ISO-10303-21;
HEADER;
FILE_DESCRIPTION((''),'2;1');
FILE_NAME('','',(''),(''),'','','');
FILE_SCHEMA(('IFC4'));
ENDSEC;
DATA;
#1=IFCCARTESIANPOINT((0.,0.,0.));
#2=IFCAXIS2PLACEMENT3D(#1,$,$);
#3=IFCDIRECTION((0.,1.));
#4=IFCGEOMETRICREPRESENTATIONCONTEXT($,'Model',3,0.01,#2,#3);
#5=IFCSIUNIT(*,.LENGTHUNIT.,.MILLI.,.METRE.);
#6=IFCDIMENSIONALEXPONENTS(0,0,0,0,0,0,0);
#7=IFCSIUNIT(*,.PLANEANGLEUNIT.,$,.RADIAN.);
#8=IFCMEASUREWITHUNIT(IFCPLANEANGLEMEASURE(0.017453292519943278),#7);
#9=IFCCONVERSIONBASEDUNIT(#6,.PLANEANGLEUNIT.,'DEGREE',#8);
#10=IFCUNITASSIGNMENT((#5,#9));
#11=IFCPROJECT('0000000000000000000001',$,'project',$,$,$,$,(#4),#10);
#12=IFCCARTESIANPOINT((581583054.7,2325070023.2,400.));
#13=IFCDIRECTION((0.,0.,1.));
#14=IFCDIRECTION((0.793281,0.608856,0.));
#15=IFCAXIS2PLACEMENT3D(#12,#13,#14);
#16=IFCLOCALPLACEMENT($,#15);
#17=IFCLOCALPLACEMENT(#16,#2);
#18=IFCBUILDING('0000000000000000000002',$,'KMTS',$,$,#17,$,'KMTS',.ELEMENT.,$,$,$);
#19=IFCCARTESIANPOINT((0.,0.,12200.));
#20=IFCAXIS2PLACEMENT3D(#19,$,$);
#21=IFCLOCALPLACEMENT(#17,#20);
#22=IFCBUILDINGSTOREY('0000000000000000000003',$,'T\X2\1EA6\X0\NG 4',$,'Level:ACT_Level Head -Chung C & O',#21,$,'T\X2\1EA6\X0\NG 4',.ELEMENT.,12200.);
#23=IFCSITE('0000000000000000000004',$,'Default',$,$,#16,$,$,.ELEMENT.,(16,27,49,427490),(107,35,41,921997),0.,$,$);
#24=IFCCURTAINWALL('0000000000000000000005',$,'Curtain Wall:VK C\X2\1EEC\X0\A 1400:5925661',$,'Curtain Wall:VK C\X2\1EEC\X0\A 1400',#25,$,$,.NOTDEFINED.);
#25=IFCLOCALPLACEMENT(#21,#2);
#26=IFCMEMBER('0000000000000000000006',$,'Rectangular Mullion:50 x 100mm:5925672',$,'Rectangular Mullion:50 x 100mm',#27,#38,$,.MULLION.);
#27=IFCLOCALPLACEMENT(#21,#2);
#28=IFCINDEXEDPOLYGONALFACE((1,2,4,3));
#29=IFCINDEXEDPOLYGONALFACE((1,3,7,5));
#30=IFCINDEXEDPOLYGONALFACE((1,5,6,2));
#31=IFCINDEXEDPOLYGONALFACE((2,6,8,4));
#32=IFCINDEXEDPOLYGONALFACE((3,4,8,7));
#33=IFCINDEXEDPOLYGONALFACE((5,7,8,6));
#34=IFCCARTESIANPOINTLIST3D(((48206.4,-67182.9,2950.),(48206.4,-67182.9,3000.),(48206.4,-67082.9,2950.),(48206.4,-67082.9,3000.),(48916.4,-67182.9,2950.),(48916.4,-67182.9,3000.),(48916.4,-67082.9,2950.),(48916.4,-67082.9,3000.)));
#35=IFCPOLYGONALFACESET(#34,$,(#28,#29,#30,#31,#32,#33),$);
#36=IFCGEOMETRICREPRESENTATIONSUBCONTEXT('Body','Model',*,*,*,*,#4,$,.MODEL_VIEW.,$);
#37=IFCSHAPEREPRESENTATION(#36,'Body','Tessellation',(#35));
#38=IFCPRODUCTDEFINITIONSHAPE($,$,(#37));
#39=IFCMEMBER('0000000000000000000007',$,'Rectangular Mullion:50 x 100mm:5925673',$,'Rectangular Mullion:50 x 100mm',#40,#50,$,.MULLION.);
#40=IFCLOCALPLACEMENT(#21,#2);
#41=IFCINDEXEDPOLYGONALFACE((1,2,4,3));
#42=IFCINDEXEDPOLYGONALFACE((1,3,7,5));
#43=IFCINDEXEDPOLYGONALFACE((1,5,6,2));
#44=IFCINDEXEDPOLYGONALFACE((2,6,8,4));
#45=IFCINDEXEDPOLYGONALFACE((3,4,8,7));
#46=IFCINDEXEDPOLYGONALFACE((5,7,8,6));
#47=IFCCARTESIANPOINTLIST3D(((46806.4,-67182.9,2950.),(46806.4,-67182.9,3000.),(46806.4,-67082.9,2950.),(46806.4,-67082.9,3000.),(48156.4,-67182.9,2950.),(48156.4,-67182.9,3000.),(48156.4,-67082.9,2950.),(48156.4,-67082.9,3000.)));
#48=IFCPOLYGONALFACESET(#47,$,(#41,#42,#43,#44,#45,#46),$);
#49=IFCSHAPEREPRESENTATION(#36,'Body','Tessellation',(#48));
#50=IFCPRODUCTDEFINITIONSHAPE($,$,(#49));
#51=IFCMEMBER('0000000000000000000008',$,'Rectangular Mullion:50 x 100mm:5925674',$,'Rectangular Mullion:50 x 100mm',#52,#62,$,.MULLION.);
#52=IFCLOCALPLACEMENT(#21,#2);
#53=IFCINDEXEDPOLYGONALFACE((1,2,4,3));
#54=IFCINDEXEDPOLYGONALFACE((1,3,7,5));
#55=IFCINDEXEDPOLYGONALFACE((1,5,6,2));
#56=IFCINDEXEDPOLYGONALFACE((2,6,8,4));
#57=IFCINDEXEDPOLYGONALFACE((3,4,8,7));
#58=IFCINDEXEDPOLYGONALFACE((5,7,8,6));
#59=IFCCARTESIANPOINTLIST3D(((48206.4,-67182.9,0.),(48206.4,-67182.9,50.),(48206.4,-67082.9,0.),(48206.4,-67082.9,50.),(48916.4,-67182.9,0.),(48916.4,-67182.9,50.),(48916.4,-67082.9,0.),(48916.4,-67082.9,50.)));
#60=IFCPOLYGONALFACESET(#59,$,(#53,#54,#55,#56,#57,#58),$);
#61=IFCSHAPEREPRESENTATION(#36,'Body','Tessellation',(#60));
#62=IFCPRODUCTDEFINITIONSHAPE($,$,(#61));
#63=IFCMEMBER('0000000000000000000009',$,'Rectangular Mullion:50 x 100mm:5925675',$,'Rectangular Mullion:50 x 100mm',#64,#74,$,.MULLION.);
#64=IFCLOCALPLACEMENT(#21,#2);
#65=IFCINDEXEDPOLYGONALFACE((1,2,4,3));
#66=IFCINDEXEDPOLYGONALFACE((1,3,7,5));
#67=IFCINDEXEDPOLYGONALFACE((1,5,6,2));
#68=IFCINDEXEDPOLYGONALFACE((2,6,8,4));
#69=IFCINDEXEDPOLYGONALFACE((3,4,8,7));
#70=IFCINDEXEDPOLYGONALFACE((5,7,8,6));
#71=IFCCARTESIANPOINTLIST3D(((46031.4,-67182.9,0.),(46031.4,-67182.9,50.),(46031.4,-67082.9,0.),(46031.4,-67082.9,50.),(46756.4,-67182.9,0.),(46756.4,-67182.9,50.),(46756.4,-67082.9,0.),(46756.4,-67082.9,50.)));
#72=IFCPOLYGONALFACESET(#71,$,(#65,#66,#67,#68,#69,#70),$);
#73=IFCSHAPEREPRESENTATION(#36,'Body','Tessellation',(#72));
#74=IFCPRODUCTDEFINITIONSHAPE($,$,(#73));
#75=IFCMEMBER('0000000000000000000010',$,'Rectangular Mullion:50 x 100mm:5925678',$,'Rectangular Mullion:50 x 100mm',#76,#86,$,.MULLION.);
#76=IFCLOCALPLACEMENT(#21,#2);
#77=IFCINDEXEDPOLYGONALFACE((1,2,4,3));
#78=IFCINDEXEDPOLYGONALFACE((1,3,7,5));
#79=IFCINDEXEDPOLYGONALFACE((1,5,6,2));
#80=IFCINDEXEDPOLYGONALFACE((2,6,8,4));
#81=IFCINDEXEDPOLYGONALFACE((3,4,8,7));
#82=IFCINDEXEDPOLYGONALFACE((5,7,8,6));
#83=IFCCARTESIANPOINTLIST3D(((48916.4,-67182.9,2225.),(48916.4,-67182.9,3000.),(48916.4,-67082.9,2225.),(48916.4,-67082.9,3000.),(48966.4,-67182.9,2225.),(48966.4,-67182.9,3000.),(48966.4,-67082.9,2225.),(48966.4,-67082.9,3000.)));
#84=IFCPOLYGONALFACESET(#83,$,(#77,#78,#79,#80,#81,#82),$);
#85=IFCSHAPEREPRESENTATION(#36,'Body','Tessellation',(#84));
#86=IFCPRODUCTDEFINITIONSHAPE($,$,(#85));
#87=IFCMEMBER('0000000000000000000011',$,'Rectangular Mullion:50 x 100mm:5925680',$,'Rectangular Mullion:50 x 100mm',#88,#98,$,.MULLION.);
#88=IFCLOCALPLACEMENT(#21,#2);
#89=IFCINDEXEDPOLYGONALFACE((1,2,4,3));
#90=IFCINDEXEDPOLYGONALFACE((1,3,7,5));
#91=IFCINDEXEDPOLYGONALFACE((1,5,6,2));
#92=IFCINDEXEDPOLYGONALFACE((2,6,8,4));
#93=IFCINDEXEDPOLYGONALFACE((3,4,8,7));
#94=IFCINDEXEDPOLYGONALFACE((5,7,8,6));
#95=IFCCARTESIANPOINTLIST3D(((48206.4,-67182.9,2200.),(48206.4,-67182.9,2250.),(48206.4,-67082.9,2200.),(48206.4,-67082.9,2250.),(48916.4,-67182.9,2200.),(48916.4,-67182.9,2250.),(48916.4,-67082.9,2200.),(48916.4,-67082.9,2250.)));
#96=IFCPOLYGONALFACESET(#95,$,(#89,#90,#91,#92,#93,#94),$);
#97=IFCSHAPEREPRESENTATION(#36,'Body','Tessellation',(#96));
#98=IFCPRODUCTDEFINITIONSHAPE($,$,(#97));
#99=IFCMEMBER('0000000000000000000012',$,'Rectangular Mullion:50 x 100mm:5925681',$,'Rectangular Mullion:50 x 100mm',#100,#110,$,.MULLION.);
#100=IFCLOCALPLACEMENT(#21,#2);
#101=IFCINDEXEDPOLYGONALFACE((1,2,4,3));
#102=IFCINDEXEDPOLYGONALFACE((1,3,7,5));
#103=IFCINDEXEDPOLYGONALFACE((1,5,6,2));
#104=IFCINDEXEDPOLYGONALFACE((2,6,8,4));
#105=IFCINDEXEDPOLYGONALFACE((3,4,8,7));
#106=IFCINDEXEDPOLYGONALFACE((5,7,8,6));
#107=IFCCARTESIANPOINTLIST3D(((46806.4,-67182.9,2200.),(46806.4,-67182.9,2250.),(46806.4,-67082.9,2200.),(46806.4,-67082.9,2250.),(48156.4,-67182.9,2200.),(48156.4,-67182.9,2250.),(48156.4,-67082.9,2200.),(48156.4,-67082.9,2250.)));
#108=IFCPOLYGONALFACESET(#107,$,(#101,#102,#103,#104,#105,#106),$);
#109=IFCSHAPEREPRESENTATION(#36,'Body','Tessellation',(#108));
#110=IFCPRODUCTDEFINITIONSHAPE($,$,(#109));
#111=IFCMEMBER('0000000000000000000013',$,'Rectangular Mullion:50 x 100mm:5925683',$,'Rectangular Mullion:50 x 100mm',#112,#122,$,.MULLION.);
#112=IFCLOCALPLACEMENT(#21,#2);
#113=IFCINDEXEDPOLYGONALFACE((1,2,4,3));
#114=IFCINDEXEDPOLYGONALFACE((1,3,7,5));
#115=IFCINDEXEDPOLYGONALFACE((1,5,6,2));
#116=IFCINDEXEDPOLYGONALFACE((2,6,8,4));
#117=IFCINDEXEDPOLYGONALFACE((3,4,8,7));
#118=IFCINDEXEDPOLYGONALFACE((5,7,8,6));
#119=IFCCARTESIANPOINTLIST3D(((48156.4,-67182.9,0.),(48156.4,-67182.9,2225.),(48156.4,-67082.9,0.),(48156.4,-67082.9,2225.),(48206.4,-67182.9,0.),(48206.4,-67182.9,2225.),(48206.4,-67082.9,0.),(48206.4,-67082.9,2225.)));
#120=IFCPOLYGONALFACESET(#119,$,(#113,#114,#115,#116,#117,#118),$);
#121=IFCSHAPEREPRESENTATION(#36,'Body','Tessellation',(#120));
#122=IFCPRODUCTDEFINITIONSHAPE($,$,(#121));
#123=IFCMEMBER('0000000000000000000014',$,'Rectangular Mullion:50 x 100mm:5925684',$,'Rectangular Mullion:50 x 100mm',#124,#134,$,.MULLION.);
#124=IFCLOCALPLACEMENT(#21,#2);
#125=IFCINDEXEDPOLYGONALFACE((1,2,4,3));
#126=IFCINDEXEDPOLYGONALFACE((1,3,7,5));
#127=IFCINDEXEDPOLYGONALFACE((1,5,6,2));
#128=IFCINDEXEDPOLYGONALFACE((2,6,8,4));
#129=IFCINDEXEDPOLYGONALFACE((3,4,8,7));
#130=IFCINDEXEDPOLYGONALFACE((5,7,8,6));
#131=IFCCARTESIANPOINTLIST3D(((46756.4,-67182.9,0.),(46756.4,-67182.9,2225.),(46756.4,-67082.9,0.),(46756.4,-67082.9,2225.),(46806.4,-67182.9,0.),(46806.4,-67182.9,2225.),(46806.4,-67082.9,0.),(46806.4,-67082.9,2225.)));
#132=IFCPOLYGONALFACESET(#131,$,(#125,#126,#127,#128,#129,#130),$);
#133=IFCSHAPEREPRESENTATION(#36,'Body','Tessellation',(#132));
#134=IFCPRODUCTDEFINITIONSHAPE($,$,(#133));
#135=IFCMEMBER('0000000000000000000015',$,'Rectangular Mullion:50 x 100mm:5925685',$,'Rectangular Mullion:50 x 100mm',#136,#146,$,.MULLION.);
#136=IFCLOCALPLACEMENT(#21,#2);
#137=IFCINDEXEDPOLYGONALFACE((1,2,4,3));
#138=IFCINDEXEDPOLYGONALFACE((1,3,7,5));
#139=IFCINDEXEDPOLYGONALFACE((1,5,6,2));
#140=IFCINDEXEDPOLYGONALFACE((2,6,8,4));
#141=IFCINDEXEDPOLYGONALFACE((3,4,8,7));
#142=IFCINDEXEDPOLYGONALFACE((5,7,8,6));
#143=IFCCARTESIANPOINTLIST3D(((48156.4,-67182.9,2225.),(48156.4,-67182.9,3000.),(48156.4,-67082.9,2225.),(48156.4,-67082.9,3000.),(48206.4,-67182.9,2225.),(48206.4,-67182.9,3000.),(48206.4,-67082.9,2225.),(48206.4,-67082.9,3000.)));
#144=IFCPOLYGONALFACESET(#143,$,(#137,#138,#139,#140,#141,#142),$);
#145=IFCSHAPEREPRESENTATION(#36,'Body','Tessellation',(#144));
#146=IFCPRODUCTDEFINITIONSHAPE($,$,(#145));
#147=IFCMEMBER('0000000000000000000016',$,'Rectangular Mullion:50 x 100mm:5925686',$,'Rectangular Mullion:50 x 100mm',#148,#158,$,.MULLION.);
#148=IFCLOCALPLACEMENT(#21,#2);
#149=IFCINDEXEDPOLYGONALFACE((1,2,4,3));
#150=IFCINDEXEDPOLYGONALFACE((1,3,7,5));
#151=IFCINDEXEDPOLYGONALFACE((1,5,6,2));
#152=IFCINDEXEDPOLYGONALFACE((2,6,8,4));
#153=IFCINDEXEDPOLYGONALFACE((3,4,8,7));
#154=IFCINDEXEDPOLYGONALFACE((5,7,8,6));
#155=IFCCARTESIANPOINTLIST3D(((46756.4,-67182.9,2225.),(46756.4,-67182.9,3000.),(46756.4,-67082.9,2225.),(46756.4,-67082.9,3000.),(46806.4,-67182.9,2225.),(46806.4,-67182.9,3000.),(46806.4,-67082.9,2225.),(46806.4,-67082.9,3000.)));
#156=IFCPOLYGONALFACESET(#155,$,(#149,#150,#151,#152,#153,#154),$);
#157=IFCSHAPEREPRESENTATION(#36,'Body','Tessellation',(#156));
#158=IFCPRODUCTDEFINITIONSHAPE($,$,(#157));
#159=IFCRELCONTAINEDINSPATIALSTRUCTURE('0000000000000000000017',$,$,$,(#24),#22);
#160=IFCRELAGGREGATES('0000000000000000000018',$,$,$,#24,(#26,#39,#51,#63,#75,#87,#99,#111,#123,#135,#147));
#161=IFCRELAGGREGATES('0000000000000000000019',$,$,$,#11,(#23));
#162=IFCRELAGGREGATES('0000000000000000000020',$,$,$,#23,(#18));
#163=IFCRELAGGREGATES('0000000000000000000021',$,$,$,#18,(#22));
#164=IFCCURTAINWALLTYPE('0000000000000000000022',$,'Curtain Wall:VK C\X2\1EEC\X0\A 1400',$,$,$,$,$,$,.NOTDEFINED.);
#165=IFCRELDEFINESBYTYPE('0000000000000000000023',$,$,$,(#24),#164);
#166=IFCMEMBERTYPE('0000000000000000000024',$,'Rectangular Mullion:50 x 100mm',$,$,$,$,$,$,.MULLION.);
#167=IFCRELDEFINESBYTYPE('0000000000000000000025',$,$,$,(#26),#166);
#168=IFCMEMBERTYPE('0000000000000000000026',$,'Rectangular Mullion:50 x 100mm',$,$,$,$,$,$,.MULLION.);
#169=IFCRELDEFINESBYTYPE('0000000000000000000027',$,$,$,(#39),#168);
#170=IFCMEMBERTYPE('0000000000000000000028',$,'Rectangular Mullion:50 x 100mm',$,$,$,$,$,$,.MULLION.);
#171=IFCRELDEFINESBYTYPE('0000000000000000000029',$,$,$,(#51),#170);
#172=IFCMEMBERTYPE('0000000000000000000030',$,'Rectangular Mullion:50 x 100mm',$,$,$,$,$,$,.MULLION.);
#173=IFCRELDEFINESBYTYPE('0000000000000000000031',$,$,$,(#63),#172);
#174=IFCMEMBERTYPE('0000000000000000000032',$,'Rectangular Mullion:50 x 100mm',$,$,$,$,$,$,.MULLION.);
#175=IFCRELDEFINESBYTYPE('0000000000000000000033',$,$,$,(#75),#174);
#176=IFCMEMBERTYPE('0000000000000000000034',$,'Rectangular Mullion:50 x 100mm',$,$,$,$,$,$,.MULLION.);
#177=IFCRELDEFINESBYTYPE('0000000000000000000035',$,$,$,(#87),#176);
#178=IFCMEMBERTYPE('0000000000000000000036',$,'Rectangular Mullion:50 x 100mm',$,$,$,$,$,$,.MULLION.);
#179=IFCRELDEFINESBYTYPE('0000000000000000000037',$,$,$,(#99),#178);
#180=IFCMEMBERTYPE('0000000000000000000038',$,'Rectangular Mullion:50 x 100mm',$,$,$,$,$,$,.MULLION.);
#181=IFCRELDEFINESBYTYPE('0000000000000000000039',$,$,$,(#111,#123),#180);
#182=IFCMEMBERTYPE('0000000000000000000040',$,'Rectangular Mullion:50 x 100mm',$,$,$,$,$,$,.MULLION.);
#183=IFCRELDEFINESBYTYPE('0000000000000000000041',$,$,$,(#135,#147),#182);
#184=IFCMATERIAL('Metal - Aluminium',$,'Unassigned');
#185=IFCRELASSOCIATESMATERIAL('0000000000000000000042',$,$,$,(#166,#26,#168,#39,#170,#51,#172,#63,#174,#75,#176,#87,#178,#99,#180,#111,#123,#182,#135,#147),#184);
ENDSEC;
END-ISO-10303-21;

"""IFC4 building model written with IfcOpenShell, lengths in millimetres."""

from ifc_helpers import new_model, entity, si_unit, converted_unit, direction, frame, origin, place, context, subcontext, project, spatial, indexed_curve, outline, extrude, source, transform, mapped, material, type_object, type_shapes, element, aggregate, save


model = new_model("IFC4")

# Units and contexts
model_context = context("Model", 3, precision=0.01, world=origin(), true_north=direction((0.0, 1.0)))
body_context = subcontext(model_context, "Body", "Model", "MODEL_VIEW")
ifc_project = project(units=[si_unit("LENGTHUNIT", "METRE", prefix="MILLI"), converted_unit("PLANEANGLEUNIT", "DEGREE", entity("IfcPlaneAngleMeasure", 0.017453292519943278), si_unit("PLANEANGLEUNIT", "RADIAN"), dimensions=[0, 0, 0, 0, 0, 0, 0])], contexts=[model_context])

# Site, building, storey
site_placement = place(None, frame((581583054.7, 2325070023.2, 400.0), z_axis=(0.0, 0.0, 1.0), x_axis=(0.793281, 0.608856, 0.0)))
site = spatial("IfcSite", under=ifc_project, at=site_placement, Name="Default", CompositionType="ELEMENT", RefLatitude=(16, 27, 49, 427490), RefLongitude=(107, 35, 41, 921997), RefElevation=0.0)
building_placement = place(site_placement, origin())
building = spatial("IfcBuilding", under=site, at=building_placement, Name="KMTS", LongName="KMTS", CompositionType="ELEMENT")
storey_placement = place(building_placement, frame((0.0, 0.0, 12200.0)))
storey = spatial("IfcBuildingStorey", under=building, at=storey_placement, Name="TẦNG 4", ObjectType="Level:ACT_Level Head -Chung C & O", LongName="TẦNG 4", CompositionType="ELEMENT", Elevation=12200.0)

# Curtain wall, members
curtain_wall_type = type_object("IfcCurtainWallType", Name="Curtain Wall:VK CỬA 1400", PredefinedType="NOTDEFINED")
curtain_wall_placement = place(storey_placement, frame((0.0, 0.0, -12200.0)))
curtain_wall = element("IfcCurtainWall", 1, at=curtain_wall_placement, inside=storey, type_object=curtain_wall_type, Name="Curtain Wall:VK CỬA 1400:5925661", ObjectType="Curtain Wall:VK CỬA 1400", PredefinedType="NOTDEFINED")
ifc_material_1 = material(Name="Metal - Aluminium", Category="Unassigned")
member_type_1 = type_object("IfcMemberType", Name="Rectangular Mullion:50 x 100mm", PredefinedType="MULLION", material=ifc_material_1)
shared_shape_1 = source(origin(), body_context, "Body", "SweptSolid", [
    extrude(outline(indexed_curve([(-25.0, -50.0), (25.0, -50.0), (25.0, 50.0), (-25.0, 50.0), (-25.0, -50.0)], self_intersect=False)), frame((-25.0, 0.0, -710.0), z_axis=(0.0, 0.0, 1.0), x_axis=(-1.0, 0.0, 0.0)), (0.0, 0.0, 1.0), 710.0),
])
type_shapes(member_type_1, [shared_shape_1])
member_1_placement = place(curtain_wall_placement, frame((48206.4, -67132.9, 15200.0), z_axis=(-1.0, 0.0, 0.0), x_axis=(0.0, 0.0, 1.0)))
member_1 = element("IfcMember", 2, at=member_1_placement, type_object=member_type_1, material=ifc_material_1, Name="Rectangular Mullion:50 x 100mm:5925672", ObjectType="Rectangular Mullion:50 x 100mm", PredefinedType="MULLION", context=body_context, shape_type="MappedRepresentation", body=[
    mapped(shared_shape_1, transform((0.0, 0.0, 0.0), scale=1.0)),
])
member_type_2 = type_object("IfcMemberType", Name="Rectangular Mullion:50 x 100mm", PredefinedType="MULLION", material=ifc_material_1)
shared_shape_2 = source(origin(), body_context, "Body", "SweptSolid", [
    extrude(outline(indexed_curve([(-25.0, -50.0), (25.0, -50.0), (25.0, 50.0), (-25.0, 50.0), (-25.0, -50.0)], self_intersect=False)), frame((-25.0, 0.0, -1350.0), z_axis=(0.0, 0.0, 1.0), x_axis=(-1.0, 0.0, 0.0)), (0.0, 0.0, 1.0), 1350.0),
])
type_shapes(member_type_2, [shared_shape_2])
member_2_placement = place(curtain_wall_placement, frame((46806.4, -67132.9, 15200.0), z_axis=(-1.0, 0.0, 0.0), x_axis=(0.0, 0.0, 1.0)))
member_2 = element("IfcMember", 3, at=member_2_placement, type_object=member_type_2, material=ifc_material_1, Name="Rectangular Mullion:50 x 100mm:5925673", ObjectType="Rectangular Mullion:50 x 100mm", PredefinedType="MULLION", context=body_context, shape_type="MappedRepresentation", body=[
    mapped(shared_shape_2, transform((0.0, 0.0, 0.0), scale=1.0)),
])
member_type_3 = type_object("IfcMemberType", Name="Rectangular Mullion:50 x 100mm", PredefinedType="MULLION", material=ifc_material_1)
shared_shape_3 = source(origin(), body_context, "Body", "SweptSolid", [
    extrude(outline(indexed_curve([(-25.0, -50.0), (25.0, -50.0), (25.0, 50.0), (-25.0, 50.0), (-25.0, -50.0)], self_intersect=False)), frame((-25.0, 0.0, -710.0), z_axis=(0.0, 0.0, 1.0), x_axis=(-1.0, 0.0, 0.0)), (0.0, 0.0, 1.0), 710.0),
])
type_shapes(member_type_3, [shared_shape_3])
member_3_placement = place(curtain_wall_placement, frame((48916.4, -67132.9, 12200.0), z_axis=(1.0, 0.0, 0.0), x_axis=(0.0, 0.0, -1.0)))
member_3 = element("IfcMember", 4, at=member_3_placement, type_object=member_type_3, material=ifc_material_1, Name="Rectangular Mullion:50 x 100mm:5925674", ObjectType="Rectangular Mullion:50 x 100mm", PredefinedType="MULLION", context=body_context, shape_type="MappedRepresentation", body=[
    mapped(shared_shape_3, transform((0.0, 0.0, 0.0), scale=1.0)),
])
member_type_4 = type_object("IfcMemberType", Name="Rectangular Mullion:50 x 100mm", PredefinedType="MULLION", material=ifc_material_1)
shared_shape_4 = source(origin(), body_context, "Body", "SweptSolid", [
    extrude(outline(indexed_curve([(-25.0, -50.0), (25.0, -50.0), (25.0, 50.0), (-25.0, 50.0), (-25.0, -50.0)], self_intersect=False)), frame((-25.0, 0.0, -725.0), z_axis=(0.0, 0.0, 1.0), x_axis=(-1.0, 0.0, 0.0)), (0.0, 0.0, 1.0), 725.0),
])
type_shapes(member_type_4, [shared_shape_4])
member_4_placement = place(curtain_wall_placement, frame((46756.4, -67132.9, 12200.0), z_axis=(1.0, 0.0, 0.0), x_axis=(0.0, 0.0, -1.0)))
member_4 = element("IfcMember", 5, at=member_4_placement, type_object=member_type_4, material=ifc_material_1, Name="Rectangular Mullion:50 x 100mm:5925675", ObjectType="Rectangular Mullion:50 x 100mm", PredefinedType="MULLION", context=body_context, shape_type="MappedRepresentation", body=[
    mapped(shared_shape_4, transform((0.0, 0.0, 0.0), scale=1.0)),
])
member_type_5 = type_object("IfcMemberType", Name="Rectangular Mullion:50 x 100mm", PredefinedType="MULLION", material=ifc_material_1)
shared_shape_5 = source(origin(), body_context, "Body", "SweptSolid", [
    extrude(outline(indexed_curve([(-25.0, -50.0), (25.0, -50.0), (25.0, 50.0), (-25.0, 50.0), (-25.0, -50.0)], self_intersect=False)), frame((-25.0, 0.0, -775.0), z_axis=(0.0, 0.0, 1.0), x_axis=(-1.0, 0.0, 0.0)), (0.0, 0.0, 1.0), 775.0),
])
type_shapes(member_type_5, [shared_shape_5])
member_5_placement = place(curtain_wall_placement, frame((48966.4, -67132.9, 15200.0)))
member_5 = element("IfcMember", 6, at=member_5_placement, type_object=member_type_5, material=ifc_material_1, Name="Rectangular Mullion:50 x 100mm:5925678", ObjectType="Rectangular Mullion:50 x 100mm", PredefinedType="MULLION", context=body_context, shape_type="MappedRepresentation", body=[
    mapped(shared_shape_5, transform((0.0, 0.0, 0.0), scale=1.0)),
])
member_type_6 = type_object("IfcMemberType", Name="Rectangular Mullion:50 x 100mm", PredefinedType="MULLION", material=ifc_material_1)
shared_shape_6 = source(origin(), body_context, "Body", "SweptSolid", [
    extrude(outline(indexed_curve([(-25.0, -50.0), (25.0, -50.0), (25.0, 50.0), (-25.0, 50.0), (-25.0, -50.0)], self_intersect=False)), frame((0.0, 0.0, -710.0), z_axis=(0.0, 0.0, 1.0), x_axis=(-1.0, 0.0, 0.0)), (0.0, 0.0, 1.0), 710.0),
])
type_shapes(member_type_6, [shared_shape_6])
member_6_placement = place(curtain_wall_placement, frame((48206.4, -67132.9, 14425.0), z_axis=(-1.0, 0.0, 0.0), x_axis=(0.0, 0.0, 1.0)))
member_6 = element("IfcMember", 7, at=member_6_placement, type_object=member_type_6, material=ifc_material_1, Name="Rectangular Mullion:50 x 100mm:5925680", ObjectType="Rectangular Mullion:50 x 100mm", PredefinedType="MULLION", context=body_context, shape_type="MappedRepresentation", body=[
    mapped(shared_shape_6, transform((0.0, 0.0, 0.0), scale=1.0)),
])
member_type_7 = type_object("IfcMemberType", Name="Rectangular Mullion:50 x 100mm", PredefinedType="MULLION", material=ifc_material_1)
shared_shape_7 = source(origin(), body_context, "Body", "SweptSolid", [
    extrude(outline(indexed_curve([(-25.0, -50.0), (25.0, -50.0), (25.0, 50.0), (-25.0, 50.0), (-25.0, -50.0)], self_intersect=False)), frame((0.0, 0.0, -1350.0), z_axis=(0.0, 0.0, 1.0), x_axis=(-1.0, 0.0, 0.0)), (0.0, 0.0, 1.0), 1350.0),
])
type_shapes(member_type_7, [shared_shape_7])
member_7_placement = place(curtain_wall_placement, frame((46806.4, -67132.9, 14425.0), z_axis=(-1.0, 0.0, 0.0), x_axis=(0.0, 0.0, 1.0)))
member_7 = element("IfcMember", 8, at=member_7_placement, type_object=member_type_7, material=ifc_material_1, Name="Rectangular Mullion:50 x 100mm:5925681", ObjectType="Rectangular Mullion:50 x 100mm", PredefinedType="MULLION", context=body_context, shape_type="MappedRepresentation", body=[
    mapped(shared_shape_7, transform((0.0, 0.0, 0.0), scale=1.0)),
])
member_type_8 = type_object("IfcMemberType", Name="Rectangular Mullion:50 x 100mm", PredefinedType="MULLION", material=ifc_material_1)
shared_shape_8 = source(origin(), body_context, "Body", "SweptSolid", [
    extrude(outline(indexed_curve([(-25.0, -50.0), (25.0, -50.0), (25.0, 50.0), (-25.0, 50.0), (-25.0, -50.0)], self_intersect=False)), frame((0.0, 0.0, -2225.0), z_axis=(0.0, 0.0, 1.0), x_axis=(-1.0, 0.0, 0.0)), (0.0, 0.0, 1.0), 2225.0),
])
type_shapes(member_type_8, [shared_shape_8])
member_8_placement = place(curtain_wall_placement, frame((48181.4, -67132.9, 12200.0), z_axis=(0.0, 0.0, -1.0), x_axis=(-1.0, 0.0, 0.0)))
member_8 = element("IfcMember", 9, at=member_8_placement, type_object=member_type_8, material=ifc_material_1, Name="Rectangular Mullion:50 x 100mm:5925683", ObjectType="Rectangular Mullion:50 x 100mm", PredefinedType="MULLION", context=body_context, shape_type="MappedRepresentation", body=[
    mapped(shared_shape_8, transform((0.0, 0.0, 0.0), scale=1.0)),
])
member_9_placement = place(curtain_wall_placement, frame((46781.4, -67132.9, 12200.0), z_axis=(0.0, 0.0, -1.0), x_axis=(-1.0, 0.0, 0.0)))
member_9 = element("IfcMember", 10, at=member_9_placement, type_object=member_type_8, material=ifc_material_1, Name="Rectangular Mullion:50 x 100mm:5925684", ObjectType="Rectangular Mullion:50 x 100mm", PredefinedType="MULLION", context=body_context, shape_type="MappedRepresentation", body=[
    mapped(shared_shape_8, transform((0.0, 0.0, 0.0), scale=1.0)),
])
member_type_9 = type_object("IfcMemberType", Name="Rectangular Mullion:50 x 100mm", PredefinedType="MULLION", material=ifc_material_1)
shared_shape_9 = source(origin(), body_context, "Body", "SweptSolid", [
    extrude(outline(indexed_curve([(-25.0, -50.0), (25.0, -50.0), (25.0, 50.0), (-25.0, 50.0), (-25.0, -50.0)], self_intersect=False)), frame((0.0, 0.0, -775.0), z_axis=(0.0, 0.0, 1.0), x_axis=(-1.0, 0.0, 0.0)), (0.0, 0.0, 1.0), 775.0),
])
type_shapes(member_type_9, [shared_shape_9])
member_10_placement = place(curtain_wall_placement, frame((48181.4, -67132.9, 14425.0), z_axis=(0.0, 0.0, -1.0), x_axis=(-1.0, 0.0, 0.0)))
member_10 = element("IfcMember", 11, at=member_10_placement, type_object=member_type_9, material=ifc_material_1, Name="Rectangular Mullion:50 x 100mm:5925685", ObjectType="Rectangular Mullion:50 x 100mm", PredefinedType="MULLION", context=body_context, shape_type="MappedRepresentation", body=[
    mapped(shared_shape_9, transform((0.0, 0.0, 0.0), scale=1.0)),
])
member_11_placement = place(curtain_wall_placement, frame((46781.4, -67132.9, 14425.0), z_axis=(0.0, 0.0, -1.0), x_axis=(-1.0, 0.0, 0.0)))
member_11 = element("IfcMember", 12, at=member_11_placement, type_object=member_type_9, material=ifc_material_1, Name="Rectangular Mullion:50 x 100mm:5925686", ObjectType="Rectangular Mullion:50 x 100mm", PredefinedType="MULLION", context=body_context, shape_type="MappedRepresentation", body=[
    mapped(shared_shape_9, transform((0.0, 0.0, 0.0), scale=1.0)),
])

aggregate(curtain_wall, [member_1, member_2, member_3, member_4, member_5, member_6, member_7, member_8, member_9, member_10, member_11])

save(model, "model.ifc")
